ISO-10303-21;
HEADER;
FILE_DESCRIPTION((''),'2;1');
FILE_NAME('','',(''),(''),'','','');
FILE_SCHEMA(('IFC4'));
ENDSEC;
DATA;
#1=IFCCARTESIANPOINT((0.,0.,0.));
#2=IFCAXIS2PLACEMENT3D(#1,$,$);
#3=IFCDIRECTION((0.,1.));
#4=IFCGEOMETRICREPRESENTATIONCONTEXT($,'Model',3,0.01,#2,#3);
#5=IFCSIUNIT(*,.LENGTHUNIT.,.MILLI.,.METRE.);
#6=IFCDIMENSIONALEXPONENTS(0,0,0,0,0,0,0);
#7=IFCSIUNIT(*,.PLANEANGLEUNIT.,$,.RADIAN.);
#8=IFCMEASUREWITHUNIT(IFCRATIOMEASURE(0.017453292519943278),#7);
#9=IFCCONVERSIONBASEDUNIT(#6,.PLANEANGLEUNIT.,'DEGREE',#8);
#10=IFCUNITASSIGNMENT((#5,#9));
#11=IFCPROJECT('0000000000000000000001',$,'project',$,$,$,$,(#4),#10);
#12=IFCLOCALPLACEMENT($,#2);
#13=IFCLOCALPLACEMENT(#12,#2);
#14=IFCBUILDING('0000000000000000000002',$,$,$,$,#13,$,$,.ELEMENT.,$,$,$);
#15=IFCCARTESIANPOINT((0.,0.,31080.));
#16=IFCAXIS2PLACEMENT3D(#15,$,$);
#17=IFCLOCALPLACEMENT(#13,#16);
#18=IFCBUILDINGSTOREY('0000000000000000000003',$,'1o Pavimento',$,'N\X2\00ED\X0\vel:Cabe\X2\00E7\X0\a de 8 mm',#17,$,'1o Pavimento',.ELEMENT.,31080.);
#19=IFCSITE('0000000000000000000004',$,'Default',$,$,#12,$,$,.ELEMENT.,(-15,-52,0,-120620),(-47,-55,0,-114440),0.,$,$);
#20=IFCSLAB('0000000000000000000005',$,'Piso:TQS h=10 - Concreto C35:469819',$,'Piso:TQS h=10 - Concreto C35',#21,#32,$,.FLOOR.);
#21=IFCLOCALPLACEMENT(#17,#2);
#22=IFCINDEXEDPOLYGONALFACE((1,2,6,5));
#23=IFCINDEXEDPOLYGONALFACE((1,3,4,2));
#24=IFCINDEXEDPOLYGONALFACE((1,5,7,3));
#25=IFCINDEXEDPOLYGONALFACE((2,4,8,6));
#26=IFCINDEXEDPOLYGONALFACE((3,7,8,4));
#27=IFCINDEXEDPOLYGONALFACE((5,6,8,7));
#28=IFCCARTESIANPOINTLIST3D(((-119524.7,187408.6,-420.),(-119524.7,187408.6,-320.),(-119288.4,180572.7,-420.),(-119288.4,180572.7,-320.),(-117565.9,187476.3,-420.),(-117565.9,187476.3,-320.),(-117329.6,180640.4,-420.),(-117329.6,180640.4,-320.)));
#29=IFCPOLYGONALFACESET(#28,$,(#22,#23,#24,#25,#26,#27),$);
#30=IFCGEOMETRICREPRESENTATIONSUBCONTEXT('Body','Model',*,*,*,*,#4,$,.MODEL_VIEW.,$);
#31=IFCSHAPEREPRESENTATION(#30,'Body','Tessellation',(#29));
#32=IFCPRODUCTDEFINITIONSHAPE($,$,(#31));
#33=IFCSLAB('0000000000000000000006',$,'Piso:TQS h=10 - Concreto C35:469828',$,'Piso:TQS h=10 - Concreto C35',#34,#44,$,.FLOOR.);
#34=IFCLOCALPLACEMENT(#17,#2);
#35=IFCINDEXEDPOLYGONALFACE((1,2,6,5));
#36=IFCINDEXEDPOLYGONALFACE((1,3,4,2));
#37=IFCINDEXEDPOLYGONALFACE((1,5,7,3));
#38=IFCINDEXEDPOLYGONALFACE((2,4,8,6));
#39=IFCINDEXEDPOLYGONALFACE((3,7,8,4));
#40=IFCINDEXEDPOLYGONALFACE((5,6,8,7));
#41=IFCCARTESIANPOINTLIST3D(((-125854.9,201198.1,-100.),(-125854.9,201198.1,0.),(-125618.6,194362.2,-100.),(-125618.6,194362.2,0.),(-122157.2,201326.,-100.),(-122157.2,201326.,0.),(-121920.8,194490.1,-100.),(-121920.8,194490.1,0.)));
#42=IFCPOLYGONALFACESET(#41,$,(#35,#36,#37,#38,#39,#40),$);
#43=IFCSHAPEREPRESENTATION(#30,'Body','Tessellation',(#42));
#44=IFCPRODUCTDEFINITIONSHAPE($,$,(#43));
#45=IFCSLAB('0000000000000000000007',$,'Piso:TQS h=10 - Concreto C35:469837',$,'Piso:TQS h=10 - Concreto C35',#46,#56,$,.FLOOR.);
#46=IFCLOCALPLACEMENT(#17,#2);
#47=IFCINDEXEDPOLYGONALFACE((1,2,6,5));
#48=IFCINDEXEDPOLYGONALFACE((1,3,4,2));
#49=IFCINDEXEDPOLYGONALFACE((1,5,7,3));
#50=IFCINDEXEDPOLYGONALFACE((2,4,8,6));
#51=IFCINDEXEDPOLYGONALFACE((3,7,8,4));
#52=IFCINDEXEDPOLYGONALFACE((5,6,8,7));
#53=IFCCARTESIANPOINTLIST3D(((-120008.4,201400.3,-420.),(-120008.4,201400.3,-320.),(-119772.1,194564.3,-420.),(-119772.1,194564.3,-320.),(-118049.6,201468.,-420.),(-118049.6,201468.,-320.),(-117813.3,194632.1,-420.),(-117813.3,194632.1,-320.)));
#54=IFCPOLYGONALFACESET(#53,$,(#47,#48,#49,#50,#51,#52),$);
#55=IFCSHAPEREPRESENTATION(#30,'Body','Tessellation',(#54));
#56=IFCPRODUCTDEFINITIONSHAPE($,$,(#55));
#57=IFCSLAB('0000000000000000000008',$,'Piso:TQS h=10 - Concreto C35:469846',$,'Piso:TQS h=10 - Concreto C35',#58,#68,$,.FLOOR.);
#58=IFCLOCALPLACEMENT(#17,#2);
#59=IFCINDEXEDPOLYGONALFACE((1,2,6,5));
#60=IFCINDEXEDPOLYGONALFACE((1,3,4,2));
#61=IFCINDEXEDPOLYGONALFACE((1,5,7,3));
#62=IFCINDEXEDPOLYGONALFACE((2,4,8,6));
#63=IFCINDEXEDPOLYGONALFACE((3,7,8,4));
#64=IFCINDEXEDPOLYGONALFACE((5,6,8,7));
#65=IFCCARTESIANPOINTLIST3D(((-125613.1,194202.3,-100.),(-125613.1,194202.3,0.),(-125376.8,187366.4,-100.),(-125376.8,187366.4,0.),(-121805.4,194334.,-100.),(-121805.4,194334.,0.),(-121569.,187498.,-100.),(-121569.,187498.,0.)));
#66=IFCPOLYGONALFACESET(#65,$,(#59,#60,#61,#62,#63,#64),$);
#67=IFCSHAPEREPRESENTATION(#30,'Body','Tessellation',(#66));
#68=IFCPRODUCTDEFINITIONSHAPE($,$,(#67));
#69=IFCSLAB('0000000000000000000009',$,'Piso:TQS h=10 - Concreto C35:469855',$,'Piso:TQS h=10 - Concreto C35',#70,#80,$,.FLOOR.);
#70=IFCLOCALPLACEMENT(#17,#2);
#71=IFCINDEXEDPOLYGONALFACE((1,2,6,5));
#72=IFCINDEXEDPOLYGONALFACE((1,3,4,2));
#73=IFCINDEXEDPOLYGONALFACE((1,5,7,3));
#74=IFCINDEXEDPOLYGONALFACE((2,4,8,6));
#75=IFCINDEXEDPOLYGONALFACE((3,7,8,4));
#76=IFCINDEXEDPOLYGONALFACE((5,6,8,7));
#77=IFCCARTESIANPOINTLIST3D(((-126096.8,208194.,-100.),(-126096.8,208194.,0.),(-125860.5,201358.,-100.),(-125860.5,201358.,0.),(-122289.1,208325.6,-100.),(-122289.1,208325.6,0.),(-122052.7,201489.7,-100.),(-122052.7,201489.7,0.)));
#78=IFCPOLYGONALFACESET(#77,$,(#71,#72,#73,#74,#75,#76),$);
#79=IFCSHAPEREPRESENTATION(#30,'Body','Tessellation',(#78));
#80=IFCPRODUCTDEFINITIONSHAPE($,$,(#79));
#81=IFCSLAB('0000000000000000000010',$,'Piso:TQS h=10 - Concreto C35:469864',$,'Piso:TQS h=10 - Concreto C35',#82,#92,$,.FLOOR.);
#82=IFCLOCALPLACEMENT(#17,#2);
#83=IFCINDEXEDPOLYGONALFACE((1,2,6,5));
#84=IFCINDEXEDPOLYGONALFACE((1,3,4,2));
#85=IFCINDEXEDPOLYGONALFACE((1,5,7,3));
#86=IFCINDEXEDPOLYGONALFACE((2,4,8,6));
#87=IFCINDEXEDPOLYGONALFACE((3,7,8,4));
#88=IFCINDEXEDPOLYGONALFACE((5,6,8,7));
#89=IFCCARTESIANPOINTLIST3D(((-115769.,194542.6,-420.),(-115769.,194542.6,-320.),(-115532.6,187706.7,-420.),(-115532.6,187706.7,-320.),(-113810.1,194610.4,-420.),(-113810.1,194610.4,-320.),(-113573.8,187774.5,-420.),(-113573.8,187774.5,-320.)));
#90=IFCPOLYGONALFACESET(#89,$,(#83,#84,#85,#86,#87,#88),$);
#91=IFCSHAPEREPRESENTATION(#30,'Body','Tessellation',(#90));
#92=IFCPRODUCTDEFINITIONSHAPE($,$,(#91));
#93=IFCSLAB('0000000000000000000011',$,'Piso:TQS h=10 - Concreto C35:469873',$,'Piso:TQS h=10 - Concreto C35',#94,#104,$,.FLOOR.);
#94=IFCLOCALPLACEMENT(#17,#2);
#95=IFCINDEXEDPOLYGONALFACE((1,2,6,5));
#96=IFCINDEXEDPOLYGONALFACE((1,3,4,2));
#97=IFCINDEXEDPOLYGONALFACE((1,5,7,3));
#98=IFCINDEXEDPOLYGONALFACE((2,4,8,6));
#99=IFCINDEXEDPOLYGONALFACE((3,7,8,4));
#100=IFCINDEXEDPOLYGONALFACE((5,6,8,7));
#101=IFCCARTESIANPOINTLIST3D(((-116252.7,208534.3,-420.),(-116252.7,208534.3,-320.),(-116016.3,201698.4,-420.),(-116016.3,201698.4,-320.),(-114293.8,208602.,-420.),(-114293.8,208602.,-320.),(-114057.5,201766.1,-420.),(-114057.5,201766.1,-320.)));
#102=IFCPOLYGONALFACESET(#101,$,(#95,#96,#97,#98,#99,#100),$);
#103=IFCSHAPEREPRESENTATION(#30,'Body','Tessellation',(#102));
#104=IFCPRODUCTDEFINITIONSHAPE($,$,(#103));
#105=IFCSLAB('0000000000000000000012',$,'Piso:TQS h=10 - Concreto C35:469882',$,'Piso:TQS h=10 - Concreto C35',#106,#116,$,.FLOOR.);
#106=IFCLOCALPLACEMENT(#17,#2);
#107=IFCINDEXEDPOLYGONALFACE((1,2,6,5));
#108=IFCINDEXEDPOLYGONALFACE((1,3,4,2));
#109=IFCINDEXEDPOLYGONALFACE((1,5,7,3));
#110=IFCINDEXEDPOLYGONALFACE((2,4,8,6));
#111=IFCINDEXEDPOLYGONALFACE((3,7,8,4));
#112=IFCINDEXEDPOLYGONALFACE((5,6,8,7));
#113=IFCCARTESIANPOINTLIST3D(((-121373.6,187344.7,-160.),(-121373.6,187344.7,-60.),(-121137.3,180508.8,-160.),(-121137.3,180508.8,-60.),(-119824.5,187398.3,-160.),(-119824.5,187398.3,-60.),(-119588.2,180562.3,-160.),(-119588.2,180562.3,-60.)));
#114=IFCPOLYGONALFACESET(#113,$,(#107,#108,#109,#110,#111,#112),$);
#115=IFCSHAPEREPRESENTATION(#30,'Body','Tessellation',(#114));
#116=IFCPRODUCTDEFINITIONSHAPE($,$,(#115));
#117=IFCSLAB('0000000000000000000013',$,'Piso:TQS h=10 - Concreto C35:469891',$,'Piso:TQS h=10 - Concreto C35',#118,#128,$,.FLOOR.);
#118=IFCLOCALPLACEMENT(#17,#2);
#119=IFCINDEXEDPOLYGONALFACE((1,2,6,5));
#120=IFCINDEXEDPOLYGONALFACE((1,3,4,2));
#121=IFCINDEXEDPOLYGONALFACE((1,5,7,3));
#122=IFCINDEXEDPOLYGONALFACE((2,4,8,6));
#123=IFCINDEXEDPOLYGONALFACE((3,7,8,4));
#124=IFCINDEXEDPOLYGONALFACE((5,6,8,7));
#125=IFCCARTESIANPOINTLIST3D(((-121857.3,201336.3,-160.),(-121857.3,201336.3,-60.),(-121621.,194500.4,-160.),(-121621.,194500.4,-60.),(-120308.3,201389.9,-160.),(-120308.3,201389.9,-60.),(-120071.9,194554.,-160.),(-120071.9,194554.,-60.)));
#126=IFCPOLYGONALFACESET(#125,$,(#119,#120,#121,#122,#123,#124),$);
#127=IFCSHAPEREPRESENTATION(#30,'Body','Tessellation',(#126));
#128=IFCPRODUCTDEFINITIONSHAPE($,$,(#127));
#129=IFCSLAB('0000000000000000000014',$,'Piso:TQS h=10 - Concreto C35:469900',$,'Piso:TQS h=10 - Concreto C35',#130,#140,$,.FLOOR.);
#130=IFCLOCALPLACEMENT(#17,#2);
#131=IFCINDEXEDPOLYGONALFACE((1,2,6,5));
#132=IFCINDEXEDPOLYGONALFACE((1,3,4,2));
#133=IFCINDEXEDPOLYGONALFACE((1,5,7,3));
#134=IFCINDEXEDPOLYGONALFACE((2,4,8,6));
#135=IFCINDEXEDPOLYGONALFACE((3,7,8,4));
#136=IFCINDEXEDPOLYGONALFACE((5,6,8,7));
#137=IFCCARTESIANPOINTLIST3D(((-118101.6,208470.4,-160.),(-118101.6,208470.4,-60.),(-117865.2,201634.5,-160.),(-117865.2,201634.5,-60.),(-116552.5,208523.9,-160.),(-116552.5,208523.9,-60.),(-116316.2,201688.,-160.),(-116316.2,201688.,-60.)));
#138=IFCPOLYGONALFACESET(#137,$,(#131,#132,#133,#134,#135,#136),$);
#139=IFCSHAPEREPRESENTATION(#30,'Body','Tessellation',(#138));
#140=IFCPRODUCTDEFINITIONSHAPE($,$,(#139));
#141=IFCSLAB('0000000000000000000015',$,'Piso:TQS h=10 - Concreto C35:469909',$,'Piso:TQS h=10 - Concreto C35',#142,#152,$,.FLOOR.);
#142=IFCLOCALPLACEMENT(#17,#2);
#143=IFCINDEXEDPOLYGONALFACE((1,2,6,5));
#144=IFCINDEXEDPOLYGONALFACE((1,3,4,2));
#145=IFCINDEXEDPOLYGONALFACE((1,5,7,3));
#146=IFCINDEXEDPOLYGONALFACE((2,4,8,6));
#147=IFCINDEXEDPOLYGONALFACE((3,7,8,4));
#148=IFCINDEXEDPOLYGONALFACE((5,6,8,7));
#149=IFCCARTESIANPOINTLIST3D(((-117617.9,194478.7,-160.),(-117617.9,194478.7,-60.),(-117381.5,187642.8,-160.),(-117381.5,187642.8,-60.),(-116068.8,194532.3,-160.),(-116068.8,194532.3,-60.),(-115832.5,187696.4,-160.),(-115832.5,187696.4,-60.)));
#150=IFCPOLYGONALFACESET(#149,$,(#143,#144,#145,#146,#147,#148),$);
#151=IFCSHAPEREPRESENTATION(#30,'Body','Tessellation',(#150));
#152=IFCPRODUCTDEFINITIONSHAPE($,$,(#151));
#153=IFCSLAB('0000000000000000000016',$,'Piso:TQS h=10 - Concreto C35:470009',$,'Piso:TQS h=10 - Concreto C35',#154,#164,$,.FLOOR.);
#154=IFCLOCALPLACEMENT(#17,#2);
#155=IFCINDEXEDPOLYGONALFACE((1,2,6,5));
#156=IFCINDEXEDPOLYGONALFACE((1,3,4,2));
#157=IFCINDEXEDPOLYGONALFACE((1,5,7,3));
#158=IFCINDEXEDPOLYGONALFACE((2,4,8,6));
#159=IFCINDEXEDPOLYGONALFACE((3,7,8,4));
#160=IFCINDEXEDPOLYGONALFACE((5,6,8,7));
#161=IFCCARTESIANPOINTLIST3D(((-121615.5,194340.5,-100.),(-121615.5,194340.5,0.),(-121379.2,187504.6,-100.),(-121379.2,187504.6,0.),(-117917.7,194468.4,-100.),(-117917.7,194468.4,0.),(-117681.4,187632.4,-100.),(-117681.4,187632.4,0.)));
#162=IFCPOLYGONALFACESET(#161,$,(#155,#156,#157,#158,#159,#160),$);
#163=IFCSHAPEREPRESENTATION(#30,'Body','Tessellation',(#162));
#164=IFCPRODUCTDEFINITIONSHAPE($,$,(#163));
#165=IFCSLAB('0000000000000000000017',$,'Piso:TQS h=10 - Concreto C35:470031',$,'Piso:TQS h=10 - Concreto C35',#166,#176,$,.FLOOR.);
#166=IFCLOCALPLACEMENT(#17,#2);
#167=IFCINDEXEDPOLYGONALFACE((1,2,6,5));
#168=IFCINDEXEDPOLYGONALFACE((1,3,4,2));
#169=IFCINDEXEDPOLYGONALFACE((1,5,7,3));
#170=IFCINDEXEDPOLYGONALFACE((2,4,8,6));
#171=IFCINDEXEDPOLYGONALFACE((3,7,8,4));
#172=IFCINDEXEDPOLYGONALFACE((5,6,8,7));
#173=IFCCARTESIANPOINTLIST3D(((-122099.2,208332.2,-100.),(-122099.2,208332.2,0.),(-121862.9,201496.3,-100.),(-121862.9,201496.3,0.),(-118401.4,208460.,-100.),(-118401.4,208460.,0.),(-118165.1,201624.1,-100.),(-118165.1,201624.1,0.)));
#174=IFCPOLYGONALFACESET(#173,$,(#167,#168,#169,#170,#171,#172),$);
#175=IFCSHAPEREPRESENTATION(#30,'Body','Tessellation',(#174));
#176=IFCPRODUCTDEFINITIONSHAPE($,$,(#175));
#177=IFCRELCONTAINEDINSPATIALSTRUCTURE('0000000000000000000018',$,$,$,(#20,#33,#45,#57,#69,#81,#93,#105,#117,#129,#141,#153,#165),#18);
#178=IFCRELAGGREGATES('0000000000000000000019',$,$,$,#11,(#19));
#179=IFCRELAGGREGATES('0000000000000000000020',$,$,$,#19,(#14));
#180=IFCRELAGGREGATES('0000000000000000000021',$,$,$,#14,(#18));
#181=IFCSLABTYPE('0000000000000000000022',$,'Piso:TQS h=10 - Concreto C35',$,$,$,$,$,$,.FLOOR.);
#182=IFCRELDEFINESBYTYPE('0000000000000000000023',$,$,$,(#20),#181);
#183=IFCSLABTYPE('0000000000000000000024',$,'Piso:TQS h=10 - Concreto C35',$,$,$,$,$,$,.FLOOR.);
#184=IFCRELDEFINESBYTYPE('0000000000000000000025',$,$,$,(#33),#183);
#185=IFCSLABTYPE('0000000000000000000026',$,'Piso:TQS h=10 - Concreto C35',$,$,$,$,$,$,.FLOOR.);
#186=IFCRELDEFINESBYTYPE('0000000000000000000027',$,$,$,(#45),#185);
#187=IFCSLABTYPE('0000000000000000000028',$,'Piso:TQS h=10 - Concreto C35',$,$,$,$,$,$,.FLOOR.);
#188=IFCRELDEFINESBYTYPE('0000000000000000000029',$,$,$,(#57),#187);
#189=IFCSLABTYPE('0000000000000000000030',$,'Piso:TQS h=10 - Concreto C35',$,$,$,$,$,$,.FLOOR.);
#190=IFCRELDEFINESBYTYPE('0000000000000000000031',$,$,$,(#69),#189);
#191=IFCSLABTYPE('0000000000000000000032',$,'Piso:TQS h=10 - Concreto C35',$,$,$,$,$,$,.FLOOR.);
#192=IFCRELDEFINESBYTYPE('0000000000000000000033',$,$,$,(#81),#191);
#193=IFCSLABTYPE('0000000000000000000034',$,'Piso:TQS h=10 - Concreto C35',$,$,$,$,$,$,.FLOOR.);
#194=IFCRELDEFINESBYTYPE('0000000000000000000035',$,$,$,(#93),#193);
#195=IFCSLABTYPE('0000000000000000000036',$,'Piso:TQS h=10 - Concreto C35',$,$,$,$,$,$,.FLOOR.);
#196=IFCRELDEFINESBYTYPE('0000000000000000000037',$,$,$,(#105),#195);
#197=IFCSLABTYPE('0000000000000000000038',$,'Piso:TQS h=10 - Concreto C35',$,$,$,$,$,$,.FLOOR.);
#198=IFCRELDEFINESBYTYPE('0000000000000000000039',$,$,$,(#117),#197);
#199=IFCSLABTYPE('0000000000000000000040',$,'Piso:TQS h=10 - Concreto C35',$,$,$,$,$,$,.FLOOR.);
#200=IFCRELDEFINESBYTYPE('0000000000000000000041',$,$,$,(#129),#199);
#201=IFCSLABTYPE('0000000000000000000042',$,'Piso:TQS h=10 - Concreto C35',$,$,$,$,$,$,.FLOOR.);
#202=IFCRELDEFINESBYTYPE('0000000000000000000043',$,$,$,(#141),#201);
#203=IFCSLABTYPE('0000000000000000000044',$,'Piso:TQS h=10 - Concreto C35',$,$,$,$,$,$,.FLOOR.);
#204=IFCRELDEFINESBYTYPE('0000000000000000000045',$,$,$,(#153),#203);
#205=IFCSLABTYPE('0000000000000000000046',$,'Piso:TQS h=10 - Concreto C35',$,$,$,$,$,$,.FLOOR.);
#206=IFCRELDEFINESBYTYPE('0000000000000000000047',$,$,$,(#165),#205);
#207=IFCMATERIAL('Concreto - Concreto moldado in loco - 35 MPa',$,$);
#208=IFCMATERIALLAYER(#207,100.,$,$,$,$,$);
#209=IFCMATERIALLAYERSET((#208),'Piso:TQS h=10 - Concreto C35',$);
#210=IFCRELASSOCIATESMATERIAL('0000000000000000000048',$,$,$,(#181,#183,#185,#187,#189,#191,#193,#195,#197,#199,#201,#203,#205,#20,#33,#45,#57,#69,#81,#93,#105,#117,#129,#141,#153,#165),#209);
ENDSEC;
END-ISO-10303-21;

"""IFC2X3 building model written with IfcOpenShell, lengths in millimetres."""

from ifc_helpers import new_model, entity, si_unit, converted_unit, direction, frame, frame_2d, origin, place, context, subcontext, project, spatial, rectangle, extrude, material, layer, layer_set, layer_usage, type_object, element, save


model = new_model("IFC2X3")

# Units and contexts
model_context = context("Model", 3, precision=0.01, world=origin(), true_north=direction((0.0, 1.0)))
body_context = subcontext(model_context, "Body", "Model", "MODEL_VIEW")
ifc_project = project(units=[si_unit("LENGTHUNIT", "METRE", prefix="MILLI"), converted_unit("PLANEANGLEUNIT", "DEGREE", entity("IfcRatioMeasure", 0.017453292519943278), si_unit("PLANEANGLEUNIT", "RADIAN"), dimensions=[0, 0, 0, 0, 0, 0, 0])], contexts=[model_context])

# Site, building, storey
site_placement = place(None, origin())
site = spatial("IfcSite", under=ifc_project, at=site_placement, Name="Default", CompositionType="ELEMENT", RefLatitude=(-15, -52, 0, -120620), RefLongitude=(-47, -55, 0, -114440), RefElevation=0.0)
building_placement = place(site_placement, origin())
building = spatial("IfcBuilding", under=site, at=building_placement, CompositionType="ELEMENT")
storey_placement = place(building_placement, frame((0.0, 0.0, 31080.0)))
storey = spatial("IfcBuildingStorey", under=building, at=storey_placement, Name="1o Pavimento", ObjectType="Nível:Cabeça de 8 mm", LongName="1o Pavimento", CompositionType="ELEMENT", Elevation=31080.0)

# Shared definitions
ifc_material = material(Name="Concreto - Concreto moldado in loco - 35 MPa")

# Slabs
ifc_layer = layer(ifc_material, 100.0)
ifc_layer_set = layer_set([ifc_layer], Name="Piso:TQS h=10 - Concreto C35")
ifc_layer_usage_1 = layer_usage(ifc_layer_set, "AXIS3", "POSITIVE", 0.0)
slab_type_1 = type_object("IfcSlabType", Name="Piso:TQS h=10 - Concreto C35", PredefinedType="FLOOR", material=ifc_layer_set)
slab_1_placement = place(storey_placement, origin())
element("IfcSlab", 1, at=slab_1_placement, inside=storey, type_object=slab_type_1, material=ifc_layer_usage_1, Name="Piso:TQS h=10 - Concreto C35:469819", ObjectType="Piso:TQS h=10 - Concreto C35", PredefinedType="FLOOR", context=body_context, shape_type="SweptSolid", body=[
    extrude(rectangle(XDim=6840.0, YDim=1960.0, at=frame_2d((0.0, 0.0), x_axis=(1.0, 0.0))), frame((-118427.1, 184024.5, -320.0), z_axis=(0.0, 0.0, -1.0), x_axis=(0.034551, -0.999403, 0.0)), (0.0, 0.0, 1.0), 100.0),
])
ifc_layer_usage_2 = layer_usage(ifc_layer_set, "AXIS3", "POSITIVE", 0.0)
slab_type_2 = type_object("IfcSlabType", Name="Piso:TQS h=10 - Concreto C35", PredefinedType="FLOOR", material=ifc_layer_set)
slab_2_placement = place(storey_placement, origin())
element("IfcSlab", 2, at=slab_2_placement, inside=storey, type_object=slab_type_2, material=ifc_layer_usage_2, Name="Piso:TQS h=10 - Concreto C35:469828", ObjectType="Piso:TQS h=10 - Concreto C35", PredefinedType="FLOOR", context=body_context, shape_type="SweptSolid", body=[
    extrude(rectangle(XDim=6840.0, YDim=3700.0, at=frame_2d((0.0, 0.0), x_axis=(1.0, 0.0))), frame((-123887.9, 197844.1, 0.0), z_axis=(0.0, 0.0, -1.0), x_axis=(0.034551, -0.999403, 0.0)), (0.0, 0.0, 1.0), 100.0),
])
ifc_layer_usage_3 = layer_usage(ifc_layer_set, "AXIS3", "POSITIVE", 0.0)
slab_type_3 = type_object("IfcSlabType", Name="Piso:TQS h=10 - Concreto C35", PredefinedType="FLOOR", material=ifc_layer_set)
slab_3_placement = place(storey_placement, origin())
element("IfcSlab", 3, at=slab_3_placement, inside=storey, type_object=slab_type_3, material=ifc_layer_usage_3, Name="Piso:TQS h=10 - Concreto C35:469837", ObjectType="Piso:TQS h=10 - Concreto C35", PredefinedType="FLOOR", context=body_context, shape_type="SweptSolid", body=[
    extrude(rectangle(XDim=6840.0, YDim=1960.0, at=frame_2d((0.0, 0.0), x_axis=(1.0, 0.0))), frame((-118910.9, 198016.2, -320.0), z_axis=(0.0, 0.0, -1.0), x_axis=(0.034551, -0.999403, 0.0)), (0.0, 0.0, 1.0), 100.0),
])
ifc_layer_usage_4 = layer_usage(ifc_layer_set, "AXIS3", "POSITIVE", 0.0)
slab_type_4 = type_object("IfcSlabType", Name="Piso:TQS h=10 - Concreto C35", PredefinedType="FLOOR", material=ifc_layer_set)
slab_4_placement = place(storey_placement, origin())
element("IfcSlab", 4, at=slab_4_placement, inside=storey, type_object=slab_type_4, material=ifc_layer_usage_4, Name="Piso:TQS h=10 - Concreto C35:469846", ObjectType="Piso:TQS h=10 - Concreto C35", PredefinedType="FLOOR", context=body_context, shape_type="SweptSolid", body=[
    extrude(rectangle(XDim=6840.0, YDim=3810.0, at=frame_2d((0.0, 0.0), x_axis=(1.0, 0.0))), frame((-123591.1, 190850.2, 0.0), z_axis=(0.0, 0.0, -1.0), x_axis=(0.034551, -0.999403, 0.0)), (0.0, 0.0, 1.0), 100.0),
])
ifc_layer_usage_5 = layer_usage(ifc_layer_set, "AXIS3", "POSITIVE", 0.0)
slab_type_5 = type_object("IfcSlabType", Name="Piso:TQS h=10 - Concreto C35", PredefinedType="FLOOR", material=ifc_layer_set)
slab_5_placement = place(storey_placement, origin())
element("IfcSlab", 5, at=slab_5_placement, inside=storey, type_object=slab_type_5, material=ifc_layer_usage_5, Name="Piso:TQS h=10 - Concreto C35:469855", ObjectType="Piso:TQS h=10 - Concreto C35", PredefinedType="FLOOR", context=body_context, shape_type="SweptSolid", body=[
    extrude(rectangle(XDim=6840.0, YDim=3810.0, at=frame_2d((0.0, 0.0), x_axis=(1.0, 0.0))), frame((-124074.8, 204841.8, 0.0), z_axis=(0.0, 0.0, -1.0), x_axis=(0.034551, -0.999403, 0.0)), (0.0, 0.0, 1.0), 100.0),
])
ifc_layer_usage_6 = layer_usage(ifc_layer_set, "AXIS3", "POSITIVE", 0.0)
slab_type_6 = type_object("IfcSlabType", Name="Piso:TQS h=10 - Concreto C35", PredefinedType="FLOOR", material=ifc_layer_set)
slab_6_placement = place(storey_placement, origin())
element("IfcSlab", 6, at=slab_6_placement, inside=storey, type_object=slab_type_6, material=ifc_layer_usage_6, Name="Piso:TQS h=10 - Concreto C35:469864", ObjectType="Piso:TQS h=10 - Concreto C35", PredefinedType="FLOOR", context=body_context, shape_type="SweptSolid", body=[
    extrude(rectangle(XDim=6840.0, YDim=1960.0, at=frame_2d((0.0, 0.0), x_axis=(1.0, 0.0))), frame((-114671.4, 191158.5, -320.0), z_axis=(0.0, 0.0, -1.0), x_axis=(0.034551, -0.999403, 0.0)), (0.0, 0.0, 1.0), 100.0),
])
ifc_layer_usage_7 = layer_usage(ifc_layer_set, "AXIS3", "POSITIVE", 0.0)
slab_type_7 = type_object("IfcSlabType", Name="Piso:TQS h=10 - Concreto C35", PredefinedType="FLOOR", material=ifc_layer_set)
slab_7_placement = place(storey_placement, origin())
element("IfcSlab", 7, at=slab_7_placement, inside=storey, type_object=slab_type_7, material=ifc_layer_usage_7, Name="Piso:TQS h=10 - Concreto C35:469873", ObjectType="Piso:TQS h=10 - Concreto C35", PredefinedType="FLOOR", context=body_context, shape_type="SweptSolid", body=[
    extrude(rectangle(XDim=6840.0, YDim=1960.0, at=frame_2d((0.0, 0.0), x_axis=(1.0, 0.0))), frame((-115155.1, 205150.2, -320.0), z_axis=(0.0, 0.0, -1.0), x_axis=(0.034551, -0.999403, 0.0)), (0.0, 0.0, 1.0), 100.0),
])
ifc_layer_usage_8 = layer_usage(ifc_layer_set, "AXIS3", "POSITIVE", 0.0)
slab_type_8 = type_object("IfcSlabType", Name="Piso:TQS h=10 - Concreto C35", PredefinedType="FLOOR", material=ifc_layer_set)
slab_8_placement = place(storey_placement, origin())
element("IfcSlab", 8, at=slab_8_placement, inside=storey, type_object=slab_type_8, material=ifc_layer_usage_8, Name="Piso:TQS h=10 - Concreto C35:469882", ObjectType="Piso:TQS h=10 - Concreto C35", PredefinedType="FLOOR", context=body_context, shape_type="SweptSolid", body=[
    extrude(rectangle(XDim=6840.0, YDim=1550.0, at=frame_2d((0.0, 0.0), x_axis=(1.0, 0.0))), frame((-120480.9, 183953.5, -60.0), z_axis=(0.0, 0.0, -1.0), x_axis=(0.034551, -0.999403, 0.0)), (0.0, 0.0, 1.0), 100.0),
])
ifc_layer_usage_9 = layer_usage(ifc_layer_set, "AXIS3", "POSITIVE", 0.0)
slab_type_9 = type_object("IfcSlabType", Name="Piso:TQS h=10 - Concreto C35", PredefinedType="FLOOR", material=ifc_layer_set)
slab_9_placement = place(storey_placement, origin())
element("IfcSlab", 9, at=slab_9_placement, inside=storey, type_object=slab_type_9, material=ifc_layer_usage_9, Name="Piso:TQS h=10 - Concreto C35:469891", ObjectType="Piso:TQS h=10 - Concreto C35", PredefinedType="FLOOR", context=body_context, shape_type="SweptSolid", body=[
    extrude(rectangle(XDim=6840.0, YDim=1550.0, at=frame_2d((0.0, 0.0), x_axis=(1.0, 0.0))), frame((-120964.6, 197945.2, -60.0), z_axis=(0.0, 0.0, -1.0), x_axis=(0.034551, -0.999403, 0.0)), (0.0, 0.0, 1.0), 100.0),
])
ifc_layer_usage_10 = layer_usage(ifc_layer_set, "AXIS3", "POSITIVE", 0.0)
slab_type_10 = type_object("IfcSlabType", Name="Piso:TQS h=10 - Concreto C35", PredefinedType="FLOOR", material=ifc_layer_set)
slab_10_placement = place(storey_placement, origin())
element("IfcSlab", 10, at=slab_10_placement, inside=storey, type_object=slab_type_10, material=ifc_layer_usage_10, Name="Piso:TQS h=10 - Concreto C35:469900", ObjectType="Piso:TQS h=10 - Concreto C35", PredefinedType="FLOOR", context=body_context, shape_type="SweptSolid", body=[
    extrude(rectangle(XDim=6840.0, YDim=1550.0, at=frame_2d((0.0, 0.0), x_axis=(1.0, 0.0))), frame((-117208.9, 205079.2, -60.0), z_axis=(0.0, 0.0, -1.0), x_axis=(0.034551, -0.999403, 0.0)), (0.0, 0.0, 1.0), 100.0),
])
ifc_layer_usage_11 = layer_usage(ifc_layer_set, "AXIS3", "POSITIVE", 0.0)
slab_type_11 = type_object("IfcSlabType", Name="Piso:TQS h=10 - Concreto C35", PredefinedType="FLOOR", material=ifc_layer_set)
slab_11_placement = place(storey_placement, origin())
element("IfcSlab", 11, at=slab_11_placement, inside=storey, type_object=slab_type_11, material=ifc_layer_usage_11, Name="Piso:TQS h=10 - Concreto C35:469909", ObjectType="Piso:TQS h=10 - Concreto C35", PredefinedType="FLOOR", context=body_context, shape_type="SweptSolid", body=[
    extrude(rectangle(XDim=6840.0, YDim=1550.0, at=frame_2d((0.0, 0.0), x_axis=(1.0, 0.0))), frame((-116725.2, 191087.5, -60.0), z_axis=(0.0, 0.0, -1.0), x_axis=(0.034551, -0.999403, 0.0)), (0.0, 0.0, 1.0), 100.0),
])
ifc_layer_usage_12 = layer_usage(ifc_layer_set, "AXIS3", "POSITIVE", 0.0)
slab_type_12 = type_object("IfcSlabType", Name="Piso:TQS h=10 - Concreto C35", PredefinedType="FLOOR", material=ifc_layer_set)
slab_12_placement = place(storey_placement, origin())
element("IfcSlab", 12, at=slab_12_placement, inside=storey, type_object=slab_type_12, material=ifc_layer_usage_12, Name="Piso:TQS h=10 - Concreto C35:470009", ObjectType="Piso:TQS h=10 - Concreto C35", PredefinedType="FLOOR", context=body_context, shape_type="SweptSolid", body=[
    extrude(rectangle(XDim=6840.0, YDim=3700.0, at=frame_2d((0.0, 0.0), x_axis=(1.0, 0.0))), frame((-119648.4, 190986.5, 0.0), z_axis=(0.0, 0.0, -1.0), x_axis=(0.034551, -0.999403, 0.0)), (0.0, 0.0, 1.0), 100.0),
])
ifc_layer_usage_13 = layer_usage(ifc_layer_set, "AXIS3", "POSITIVE", 0.0)
slab_type_13 = type_object("IfcSlabType", Name="Piso:TQS h=10 - Concreto C35", PredefinedType="FLOOR", material=ifc_layer_set)
slab_13_placement = place(storey_placement, origin())
element("IfcSlab", 13, at=slab_13_placement, inside=storey, type_object=slab_type_13, material=ifc_layer_usage_13, Name="Piso:TQS h=10 - Concreto C35:470031", ObjectType="Piso:TQS h=10 - Concreto C35", PredefinedType="FLOOR", context=body_context, shape_type="SweptSolid", body=[
    extrude(rectangle(XDim=6840.0, YDim=3700.0, at=frame_2d((0.0, 0.0), x_axis=(1.0, 0.0))), frame((-120132.1, 204978.1, 0.0), z_axis=(0.0, 0.0, -1.0), x_axis=(0.034551, -0.999403, 0.0)), (0.0, 0.0, 1.0), 100.0),
])

save(model, "model.ifc")
